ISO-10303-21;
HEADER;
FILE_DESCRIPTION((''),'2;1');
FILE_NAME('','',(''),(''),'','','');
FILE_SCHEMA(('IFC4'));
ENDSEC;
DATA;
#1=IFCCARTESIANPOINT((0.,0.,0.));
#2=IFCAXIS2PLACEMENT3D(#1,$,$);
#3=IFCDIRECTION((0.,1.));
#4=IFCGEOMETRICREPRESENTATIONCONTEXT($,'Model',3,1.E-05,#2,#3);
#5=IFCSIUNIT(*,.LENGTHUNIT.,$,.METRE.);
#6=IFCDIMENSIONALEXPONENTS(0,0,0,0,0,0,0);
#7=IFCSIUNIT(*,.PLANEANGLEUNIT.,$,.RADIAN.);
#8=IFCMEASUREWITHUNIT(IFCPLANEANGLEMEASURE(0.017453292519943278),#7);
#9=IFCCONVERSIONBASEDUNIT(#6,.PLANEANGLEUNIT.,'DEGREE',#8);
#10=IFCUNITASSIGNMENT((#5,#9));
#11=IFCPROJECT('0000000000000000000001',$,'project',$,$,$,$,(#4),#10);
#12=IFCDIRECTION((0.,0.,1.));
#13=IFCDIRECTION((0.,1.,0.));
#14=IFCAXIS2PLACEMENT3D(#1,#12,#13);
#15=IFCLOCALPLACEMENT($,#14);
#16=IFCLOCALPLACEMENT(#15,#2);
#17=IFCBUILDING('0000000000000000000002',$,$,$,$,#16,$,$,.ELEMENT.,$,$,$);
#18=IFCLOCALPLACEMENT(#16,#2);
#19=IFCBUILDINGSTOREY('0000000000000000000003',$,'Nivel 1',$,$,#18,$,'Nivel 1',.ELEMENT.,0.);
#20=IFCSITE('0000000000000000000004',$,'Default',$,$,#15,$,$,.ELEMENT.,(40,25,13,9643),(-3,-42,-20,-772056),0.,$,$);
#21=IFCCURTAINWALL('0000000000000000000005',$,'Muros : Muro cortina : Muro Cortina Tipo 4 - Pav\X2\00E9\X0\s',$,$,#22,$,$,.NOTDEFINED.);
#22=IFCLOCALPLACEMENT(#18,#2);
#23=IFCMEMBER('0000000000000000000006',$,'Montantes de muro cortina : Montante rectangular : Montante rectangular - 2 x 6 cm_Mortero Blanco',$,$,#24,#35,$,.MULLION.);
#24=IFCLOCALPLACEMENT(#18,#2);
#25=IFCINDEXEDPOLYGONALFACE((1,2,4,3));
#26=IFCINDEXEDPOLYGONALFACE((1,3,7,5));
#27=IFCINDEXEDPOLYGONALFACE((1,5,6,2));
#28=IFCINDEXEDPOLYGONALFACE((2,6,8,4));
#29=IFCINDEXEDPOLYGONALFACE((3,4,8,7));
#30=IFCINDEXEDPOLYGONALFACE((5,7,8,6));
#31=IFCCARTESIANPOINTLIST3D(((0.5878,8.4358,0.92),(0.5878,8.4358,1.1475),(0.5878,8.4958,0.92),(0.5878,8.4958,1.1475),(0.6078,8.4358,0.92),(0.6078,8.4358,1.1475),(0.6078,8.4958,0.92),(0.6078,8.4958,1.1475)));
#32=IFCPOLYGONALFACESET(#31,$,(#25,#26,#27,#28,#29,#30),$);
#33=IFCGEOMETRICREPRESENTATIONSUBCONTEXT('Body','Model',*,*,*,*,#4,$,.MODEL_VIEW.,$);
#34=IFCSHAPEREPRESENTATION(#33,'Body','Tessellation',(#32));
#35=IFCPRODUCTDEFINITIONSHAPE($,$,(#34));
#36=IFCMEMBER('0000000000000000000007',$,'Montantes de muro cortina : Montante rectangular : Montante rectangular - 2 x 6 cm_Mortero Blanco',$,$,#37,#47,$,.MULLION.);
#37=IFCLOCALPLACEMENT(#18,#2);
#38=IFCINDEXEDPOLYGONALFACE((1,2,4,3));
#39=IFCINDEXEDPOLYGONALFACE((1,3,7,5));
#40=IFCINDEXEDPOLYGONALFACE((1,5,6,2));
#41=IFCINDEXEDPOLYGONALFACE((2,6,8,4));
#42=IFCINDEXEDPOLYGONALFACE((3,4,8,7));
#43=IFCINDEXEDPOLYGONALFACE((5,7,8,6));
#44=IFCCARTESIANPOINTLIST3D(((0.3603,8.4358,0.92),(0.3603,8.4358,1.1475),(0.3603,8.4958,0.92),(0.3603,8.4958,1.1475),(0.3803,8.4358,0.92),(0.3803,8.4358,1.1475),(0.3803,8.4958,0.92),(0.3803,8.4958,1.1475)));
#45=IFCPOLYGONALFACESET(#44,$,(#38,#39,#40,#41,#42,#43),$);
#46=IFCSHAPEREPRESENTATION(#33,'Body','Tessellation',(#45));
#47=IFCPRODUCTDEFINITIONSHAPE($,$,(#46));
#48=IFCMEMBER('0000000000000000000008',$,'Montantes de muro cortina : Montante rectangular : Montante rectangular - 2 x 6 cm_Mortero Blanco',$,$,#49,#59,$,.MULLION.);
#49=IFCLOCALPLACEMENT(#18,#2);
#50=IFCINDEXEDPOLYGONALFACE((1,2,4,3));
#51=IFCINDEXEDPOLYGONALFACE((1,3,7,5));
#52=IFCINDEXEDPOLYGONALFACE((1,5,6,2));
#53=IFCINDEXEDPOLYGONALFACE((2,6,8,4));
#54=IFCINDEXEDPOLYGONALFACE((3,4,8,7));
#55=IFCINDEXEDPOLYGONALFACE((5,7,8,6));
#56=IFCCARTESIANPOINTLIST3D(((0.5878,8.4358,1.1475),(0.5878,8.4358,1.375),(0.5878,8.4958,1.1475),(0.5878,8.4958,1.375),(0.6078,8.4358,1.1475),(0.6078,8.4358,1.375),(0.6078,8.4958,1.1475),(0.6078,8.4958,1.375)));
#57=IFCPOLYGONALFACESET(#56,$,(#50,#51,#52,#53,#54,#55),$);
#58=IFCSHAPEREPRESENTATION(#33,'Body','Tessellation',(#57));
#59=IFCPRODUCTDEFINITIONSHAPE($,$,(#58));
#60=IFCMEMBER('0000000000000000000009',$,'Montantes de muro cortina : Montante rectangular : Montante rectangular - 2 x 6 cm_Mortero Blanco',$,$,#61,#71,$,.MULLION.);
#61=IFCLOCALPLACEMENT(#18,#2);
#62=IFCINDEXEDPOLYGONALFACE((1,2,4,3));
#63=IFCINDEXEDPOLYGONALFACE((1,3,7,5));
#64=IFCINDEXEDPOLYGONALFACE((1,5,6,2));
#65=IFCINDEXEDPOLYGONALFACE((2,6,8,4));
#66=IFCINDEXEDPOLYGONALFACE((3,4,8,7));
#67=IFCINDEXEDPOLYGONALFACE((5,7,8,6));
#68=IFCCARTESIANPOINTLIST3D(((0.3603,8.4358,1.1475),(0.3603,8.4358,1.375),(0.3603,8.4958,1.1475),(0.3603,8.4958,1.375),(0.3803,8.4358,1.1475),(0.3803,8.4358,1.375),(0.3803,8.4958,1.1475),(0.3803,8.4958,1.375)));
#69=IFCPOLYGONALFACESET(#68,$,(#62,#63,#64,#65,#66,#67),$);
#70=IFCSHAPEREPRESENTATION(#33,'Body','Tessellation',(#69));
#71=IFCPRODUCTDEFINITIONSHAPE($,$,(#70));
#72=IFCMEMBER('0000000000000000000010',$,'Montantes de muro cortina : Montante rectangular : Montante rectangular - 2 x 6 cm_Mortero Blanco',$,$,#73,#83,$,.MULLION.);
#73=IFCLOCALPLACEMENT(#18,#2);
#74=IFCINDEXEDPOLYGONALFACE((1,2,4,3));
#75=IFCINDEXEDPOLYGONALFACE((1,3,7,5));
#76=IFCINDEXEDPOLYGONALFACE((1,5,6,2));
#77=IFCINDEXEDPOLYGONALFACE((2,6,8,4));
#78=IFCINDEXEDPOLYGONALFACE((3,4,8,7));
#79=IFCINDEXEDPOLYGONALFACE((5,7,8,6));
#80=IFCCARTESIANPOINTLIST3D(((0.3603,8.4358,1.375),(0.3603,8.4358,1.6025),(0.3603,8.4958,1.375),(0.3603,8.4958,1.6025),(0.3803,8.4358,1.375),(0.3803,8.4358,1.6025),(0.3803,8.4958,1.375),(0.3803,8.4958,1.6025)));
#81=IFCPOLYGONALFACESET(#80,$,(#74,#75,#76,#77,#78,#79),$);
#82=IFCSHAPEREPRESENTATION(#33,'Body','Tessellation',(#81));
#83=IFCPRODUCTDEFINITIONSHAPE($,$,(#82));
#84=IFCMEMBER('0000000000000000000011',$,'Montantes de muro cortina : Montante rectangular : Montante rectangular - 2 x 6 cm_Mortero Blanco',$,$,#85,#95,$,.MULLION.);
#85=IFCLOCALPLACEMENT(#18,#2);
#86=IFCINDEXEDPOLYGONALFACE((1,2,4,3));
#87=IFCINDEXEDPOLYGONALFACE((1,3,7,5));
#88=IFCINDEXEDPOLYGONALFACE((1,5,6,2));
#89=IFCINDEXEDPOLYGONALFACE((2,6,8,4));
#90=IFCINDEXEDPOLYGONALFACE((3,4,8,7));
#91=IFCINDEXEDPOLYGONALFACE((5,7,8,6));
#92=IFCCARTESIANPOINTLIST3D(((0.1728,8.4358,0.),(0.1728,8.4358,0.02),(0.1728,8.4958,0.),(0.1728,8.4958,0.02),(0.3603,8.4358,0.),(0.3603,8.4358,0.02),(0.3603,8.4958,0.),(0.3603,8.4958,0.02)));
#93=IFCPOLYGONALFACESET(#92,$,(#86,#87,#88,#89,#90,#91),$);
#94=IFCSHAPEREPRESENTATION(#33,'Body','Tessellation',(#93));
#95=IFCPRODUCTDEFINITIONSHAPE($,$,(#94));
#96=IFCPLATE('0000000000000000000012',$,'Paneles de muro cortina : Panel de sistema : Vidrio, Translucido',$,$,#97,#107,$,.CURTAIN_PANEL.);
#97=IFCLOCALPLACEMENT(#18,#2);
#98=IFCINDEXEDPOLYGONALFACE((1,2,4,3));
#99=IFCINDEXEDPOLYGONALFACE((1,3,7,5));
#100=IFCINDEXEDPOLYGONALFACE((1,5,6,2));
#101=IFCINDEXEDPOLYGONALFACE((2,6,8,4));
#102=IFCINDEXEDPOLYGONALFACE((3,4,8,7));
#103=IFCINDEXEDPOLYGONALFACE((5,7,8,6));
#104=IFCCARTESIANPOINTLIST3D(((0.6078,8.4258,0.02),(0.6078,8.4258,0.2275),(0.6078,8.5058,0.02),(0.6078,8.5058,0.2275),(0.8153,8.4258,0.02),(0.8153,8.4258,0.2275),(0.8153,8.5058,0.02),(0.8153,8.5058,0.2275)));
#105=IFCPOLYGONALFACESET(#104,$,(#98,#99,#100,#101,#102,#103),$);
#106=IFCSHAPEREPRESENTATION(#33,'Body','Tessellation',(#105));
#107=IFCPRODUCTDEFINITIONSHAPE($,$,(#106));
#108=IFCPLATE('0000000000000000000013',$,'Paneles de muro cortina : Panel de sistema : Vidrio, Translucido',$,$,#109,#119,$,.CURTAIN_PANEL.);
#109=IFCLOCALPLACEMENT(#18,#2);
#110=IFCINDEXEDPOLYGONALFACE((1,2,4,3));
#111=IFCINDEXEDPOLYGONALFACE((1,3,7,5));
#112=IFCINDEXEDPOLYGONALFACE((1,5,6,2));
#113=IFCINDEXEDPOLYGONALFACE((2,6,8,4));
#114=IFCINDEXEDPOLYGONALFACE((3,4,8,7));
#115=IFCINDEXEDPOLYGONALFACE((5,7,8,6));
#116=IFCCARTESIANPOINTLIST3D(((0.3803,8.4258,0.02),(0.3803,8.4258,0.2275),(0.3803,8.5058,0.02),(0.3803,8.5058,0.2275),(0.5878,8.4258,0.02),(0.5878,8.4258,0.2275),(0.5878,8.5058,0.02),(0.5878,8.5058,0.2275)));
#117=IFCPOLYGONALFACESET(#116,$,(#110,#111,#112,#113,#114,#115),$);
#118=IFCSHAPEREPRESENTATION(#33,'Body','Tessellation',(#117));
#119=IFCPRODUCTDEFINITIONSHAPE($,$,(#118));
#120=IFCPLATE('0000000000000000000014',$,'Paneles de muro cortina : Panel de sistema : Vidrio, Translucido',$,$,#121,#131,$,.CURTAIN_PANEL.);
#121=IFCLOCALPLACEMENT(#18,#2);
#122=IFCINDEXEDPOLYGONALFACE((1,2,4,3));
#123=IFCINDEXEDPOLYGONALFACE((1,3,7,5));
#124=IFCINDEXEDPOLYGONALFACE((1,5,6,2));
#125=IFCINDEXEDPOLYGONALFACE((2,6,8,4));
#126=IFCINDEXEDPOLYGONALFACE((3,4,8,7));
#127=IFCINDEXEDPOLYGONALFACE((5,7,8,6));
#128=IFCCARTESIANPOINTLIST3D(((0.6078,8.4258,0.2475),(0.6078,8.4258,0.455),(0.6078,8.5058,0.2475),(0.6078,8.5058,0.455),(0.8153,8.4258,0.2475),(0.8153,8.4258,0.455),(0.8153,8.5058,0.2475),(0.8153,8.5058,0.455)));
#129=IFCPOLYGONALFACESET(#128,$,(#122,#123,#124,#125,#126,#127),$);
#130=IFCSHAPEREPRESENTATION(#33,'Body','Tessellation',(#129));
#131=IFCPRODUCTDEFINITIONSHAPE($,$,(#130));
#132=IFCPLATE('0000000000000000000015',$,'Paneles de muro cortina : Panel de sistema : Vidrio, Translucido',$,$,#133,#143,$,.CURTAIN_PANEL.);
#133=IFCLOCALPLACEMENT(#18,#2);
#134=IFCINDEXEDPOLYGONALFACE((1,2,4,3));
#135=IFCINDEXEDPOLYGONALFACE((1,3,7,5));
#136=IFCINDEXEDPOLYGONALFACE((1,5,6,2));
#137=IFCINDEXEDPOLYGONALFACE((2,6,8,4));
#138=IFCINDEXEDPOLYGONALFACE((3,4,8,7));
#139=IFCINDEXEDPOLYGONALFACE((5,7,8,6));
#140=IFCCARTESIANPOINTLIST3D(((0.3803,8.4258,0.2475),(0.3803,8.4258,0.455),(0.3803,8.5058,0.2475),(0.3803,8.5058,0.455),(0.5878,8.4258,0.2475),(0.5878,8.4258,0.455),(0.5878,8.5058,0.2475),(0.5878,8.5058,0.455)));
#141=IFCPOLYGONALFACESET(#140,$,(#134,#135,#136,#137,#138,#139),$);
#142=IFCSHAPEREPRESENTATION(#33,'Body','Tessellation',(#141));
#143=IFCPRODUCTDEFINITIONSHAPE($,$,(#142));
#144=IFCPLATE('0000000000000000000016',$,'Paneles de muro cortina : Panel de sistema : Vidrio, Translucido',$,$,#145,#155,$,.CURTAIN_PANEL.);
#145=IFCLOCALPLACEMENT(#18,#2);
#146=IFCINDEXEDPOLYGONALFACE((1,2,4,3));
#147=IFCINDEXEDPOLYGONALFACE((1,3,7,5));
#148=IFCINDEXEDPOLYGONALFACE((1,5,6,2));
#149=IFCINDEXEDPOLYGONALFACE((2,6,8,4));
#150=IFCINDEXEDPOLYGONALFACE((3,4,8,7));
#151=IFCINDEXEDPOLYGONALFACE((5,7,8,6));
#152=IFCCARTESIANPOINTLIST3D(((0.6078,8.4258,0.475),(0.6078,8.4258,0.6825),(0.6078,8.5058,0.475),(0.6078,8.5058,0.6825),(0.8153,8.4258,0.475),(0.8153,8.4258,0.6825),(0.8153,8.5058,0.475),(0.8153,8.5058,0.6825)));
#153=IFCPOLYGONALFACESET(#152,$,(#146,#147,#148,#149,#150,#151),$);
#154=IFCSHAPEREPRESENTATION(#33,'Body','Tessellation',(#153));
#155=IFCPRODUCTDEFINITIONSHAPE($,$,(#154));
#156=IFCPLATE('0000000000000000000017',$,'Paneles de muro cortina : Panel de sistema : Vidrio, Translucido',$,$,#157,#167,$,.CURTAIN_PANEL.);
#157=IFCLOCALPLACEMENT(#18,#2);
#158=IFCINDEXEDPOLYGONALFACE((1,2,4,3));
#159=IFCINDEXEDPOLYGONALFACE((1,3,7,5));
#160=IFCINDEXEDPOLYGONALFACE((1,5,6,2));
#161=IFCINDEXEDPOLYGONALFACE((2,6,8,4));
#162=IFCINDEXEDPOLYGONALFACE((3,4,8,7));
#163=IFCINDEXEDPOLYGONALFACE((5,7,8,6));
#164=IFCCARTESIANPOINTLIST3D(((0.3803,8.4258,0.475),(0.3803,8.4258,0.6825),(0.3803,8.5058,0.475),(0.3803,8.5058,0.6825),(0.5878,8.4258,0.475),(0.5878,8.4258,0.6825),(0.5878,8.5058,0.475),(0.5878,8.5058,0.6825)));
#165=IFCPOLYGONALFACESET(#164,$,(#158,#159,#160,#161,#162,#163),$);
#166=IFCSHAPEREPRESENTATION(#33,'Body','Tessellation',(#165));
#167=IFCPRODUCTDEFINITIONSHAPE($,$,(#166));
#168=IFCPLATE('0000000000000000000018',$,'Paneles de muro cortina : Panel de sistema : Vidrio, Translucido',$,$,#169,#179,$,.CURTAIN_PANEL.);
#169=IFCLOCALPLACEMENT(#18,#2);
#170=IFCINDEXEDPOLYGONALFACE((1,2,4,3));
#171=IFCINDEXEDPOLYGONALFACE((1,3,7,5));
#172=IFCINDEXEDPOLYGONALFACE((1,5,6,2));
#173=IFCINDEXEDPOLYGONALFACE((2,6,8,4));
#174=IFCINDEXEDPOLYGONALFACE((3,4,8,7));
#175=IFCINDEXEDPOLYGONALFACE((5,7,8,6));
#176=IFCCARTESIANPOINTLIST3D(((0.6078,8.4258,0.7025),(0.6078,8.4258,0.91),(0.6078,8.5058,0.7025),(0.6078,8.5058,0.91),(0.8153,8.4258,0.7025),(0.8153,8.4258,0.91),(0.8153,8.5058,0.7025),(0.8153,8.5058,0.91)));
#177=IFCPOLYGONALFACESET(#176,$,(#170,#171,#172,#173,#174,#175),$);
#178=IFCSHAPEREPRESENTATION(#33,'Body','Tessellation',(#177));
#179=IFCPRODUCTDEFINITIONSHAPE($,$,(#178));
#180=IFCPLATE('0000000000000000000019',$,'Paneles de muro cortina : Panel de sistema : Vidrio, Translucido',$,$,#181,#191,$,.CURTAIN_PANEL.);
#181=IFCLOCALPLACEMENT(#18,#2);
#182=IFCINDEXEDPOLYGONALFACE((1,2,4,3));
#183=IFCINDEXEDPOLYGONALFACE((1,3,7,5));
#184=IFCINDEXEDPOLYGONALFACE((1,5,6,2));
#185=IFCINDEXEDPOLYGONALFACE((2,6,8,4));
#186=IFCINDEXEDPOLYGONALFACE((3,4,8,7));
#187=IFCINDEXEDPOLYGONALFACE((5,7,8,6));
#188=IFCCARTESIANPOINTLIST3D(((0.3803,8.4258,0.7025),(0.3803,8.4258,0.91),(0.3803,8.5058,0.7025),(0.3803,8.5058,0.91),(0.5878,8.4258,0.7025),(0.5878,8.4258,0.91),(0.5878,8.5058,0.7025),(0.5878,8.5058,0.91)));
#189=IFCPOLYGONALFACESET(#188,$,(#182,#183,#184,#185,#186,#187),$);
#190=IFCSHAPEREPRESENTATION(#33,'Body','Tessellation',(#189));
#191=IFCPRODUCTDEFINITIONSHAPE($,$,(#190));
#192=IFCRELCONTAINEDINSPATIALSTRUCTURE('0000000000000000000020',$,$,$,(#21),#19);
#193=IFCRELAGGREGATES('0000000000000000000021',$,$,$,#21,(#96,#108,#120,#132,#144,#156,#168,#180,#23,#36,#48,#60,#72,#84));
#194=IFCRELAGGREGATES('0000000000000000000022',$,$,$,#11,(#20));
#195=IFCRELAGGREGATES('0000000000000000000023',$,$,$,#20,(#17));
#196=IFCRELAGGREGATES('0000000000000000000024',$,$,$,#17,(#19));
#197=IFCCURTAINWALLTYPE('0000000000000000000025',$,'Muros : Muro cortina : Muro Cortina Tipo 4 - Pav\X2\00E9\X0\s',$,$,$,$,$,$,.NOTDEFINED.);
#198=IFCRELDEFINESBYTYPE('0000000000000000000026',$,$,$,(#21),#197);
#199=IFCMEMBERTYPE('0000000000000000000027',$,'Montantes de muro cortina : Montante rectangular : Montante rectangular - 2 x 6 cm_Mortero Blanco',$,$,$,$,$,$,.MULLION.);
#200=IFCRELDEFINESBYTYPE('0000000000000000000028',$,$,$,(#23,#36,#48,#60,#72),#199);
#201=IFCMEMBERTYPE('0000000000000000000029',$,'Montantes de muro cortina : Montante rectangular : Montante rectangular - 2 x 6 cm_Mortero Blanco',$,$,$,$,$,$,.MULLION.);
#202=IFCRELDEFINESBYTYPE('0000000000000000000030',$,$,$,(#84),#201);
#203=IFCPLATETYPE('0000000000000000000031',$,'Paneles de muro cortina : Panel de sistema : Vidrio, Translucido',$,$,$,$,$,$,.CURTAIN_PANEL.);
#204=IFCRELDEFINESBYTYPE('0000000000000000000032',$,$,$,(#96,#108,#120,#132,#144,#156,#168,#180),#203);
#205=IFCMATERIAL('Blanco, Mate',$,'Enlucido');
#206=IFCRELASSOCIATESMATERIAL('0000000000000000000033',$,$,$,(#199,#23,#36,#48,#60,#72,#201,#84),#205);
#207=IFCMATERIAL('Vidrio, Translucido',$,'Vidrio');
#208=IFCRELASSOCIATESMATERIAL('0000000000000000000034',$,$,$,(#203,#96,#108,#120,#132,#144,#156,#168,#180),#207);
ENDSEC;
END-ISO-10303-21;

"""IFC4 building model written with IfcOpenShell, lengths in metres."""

from ifc_helpers import new_model, entity, si_unit, converted_unit, direction, frame, origin, place, context, subcontext, project, spatial, indexed_curve, outline, extrude, source, transform, mapped, material, type_object, type_shapes, element, aggregate, save


model = new_model("IFC4")

# Units and contexts
model_context = context("Model", 3, precision=1e-05, world=origin(), true_north=direction((0.0, 1.0)))
body_context = subcontext(model_context, "Body", "Model", "MODEL_VIEW")
ifc_project = project(units=[si_unit("LENGTHUNIT", "METRE"), converted_unit("PLANEANGLEUNIT", "DEGREE", entity("IfcPlaneAngleMeasure", 0.017453292519943278), si_unit("PLANEANGLEUNIT", "RADIAN"), dimensions=[0, 0, 0, 0, 0, 0, 0])], contexts=[model_context])

# Site, building, storey
site_placement = place(None, frame((0.0, 0.0, 0.0), z_axis=(0.0, 0.0, 1.0), x_axis=(0.0, 1.0, 0.0)))
site = spatial("IfcSite", under=ifc_project, at=site_placement, Name="Default", CompositionType="ELEMENT", RefLatitude=(40, 25, 13, 9643), RefLongitude=(-3, -42, -20, -772056), RefElevation=0.0)
building_placement = place(site_placement, origin())
building = spatial("IfcBuilding", under=site, at=building_placement, CompositionType="ELEMENT")
storey_placement = place(building_placement, origin())
storey = spatial("IfcBuildingStorey", under=building, at=storey_placement, Name="Nivel 1", LongName="Nivel 1", CompositionType="ELEMENT", Elevation=0.0)

# Curtain wall, members, plates
curtain_wall_type = type_object("IfcCurtainWallType", Name="Muros : Muro cortina : Muro Cortina Tipo 4 - Pavés", PredefinedType="NOTDEFINED")
curtain_wall_placement = place(storey_placement, origin())
curtain_wall = element("IfcCurtainWall", 1, at=curtain_wall_placement, inside=storey, type_object=curtain_wall_type, Name="Muros : Muro cortina : Muro Cortina Tipo 4 - Pavés", PredefinedType="NOTDEFINED")
ifc_material_1 = material(Name="Blanco, Mate", Category="Enlucido")
member_type_1 = type_object("IfcMemberType", Name="Montantes de muro cortina : Montante rectangular : Montante rectangular - 2 x 6 cm_Mortero Blanco", PredefinedType="MULLION", material=ifc_material_1)
shared_shape_1 = source(origin(), body_context, "Body", "SweptSolid", [
    extrude(outline(indexed_curve([(-0.01, -0.03), (0.01, -0.03), (0.01, 0.03), (-0.01, 0.03), (-0.01, -0.03)], self_intersect=False)), frame((0.0, 0.0, -0.2275), z_axis=(0.0, 0.0, 1.0), x_axis=(-1.0, 0.0, 0.0)), (0.0, 0.0, 1.0), 0.2275),
])
type_shapes(member_type_1, [shared_shape_1])
member_1_placement = place(curtain_wall_placement, frame((0.5978, 8.4658, 0.92), z_axis=(0.0, 0.0, -1.0), x_axis=(-1.0, 0.0, 0.0)))
member_1 = element("IfcMember", 2, at=member_1_placement, type_object=member_type_1, material=ifc_material_1, Name="Montantes de muro cortina : Montante rectangular : Montante rectangular - 2 x 6 cm_Mortero Blanco", PredefinedType="MULLION", context=body_context, shape_type="MappedRepresentation", body=[
    mapped(shared_shape_1, transform((0.0, 0.0, 0.0), scale=1.0)),
])
member_2_placement = place(curtain_wall_placement, frame((0.3703, 8.4658, 0.92), z_axis=(0.0, 0.0, -1.0), x_axis=(-1.0, 0.0, 0.0)))
member_2 = element("IfcMember", 3, at=member_2_placement, type_object=member_type_1, material=ifc_material_1, Name="Montantes de muro cortina : Montante rectangular : Montante rectangular - 2 x 6 cm_Mortero Blanco", PredefinedType="MULLION", context=body_context, shape_type="MappedRepresentation", body=[
    mapped(shared_shape_1, transform((0.0, 0.0, 0.0), scale=1.0)),
])
member_3_placement = place(curtain_wall_placement, frame((0.5978, 8.4658, 1.1475), z_axis=(0.0, 0.0, -1.0), x_axis=(-1.0, 0.0, 0.0)))
member_3 = element("IfcMember", 4, at=member_3_placement, type_object=member_type_1, material=ifc_material_1, Name="Montantes de muro cortina : Montante rectangular : Montante rectangular - 2 x 6 cm_Mortero Blanco", PredefinedType="MULLION", context=body_context, shape_type="MappedRepresentation", body=[
    mapped(shared_shape_1, transform((0.0, 0.0, 0.0), scale=1.0)),
])
member_4_placement = place(curtain_wall_placement, frame((0.3703, 8.4658, 1.1475), z_axis=(0.0, 0.0, -1.0), x_axis=(-1.0, 0.0, 0.0)))
member_4 = element("IfcMember", 5, at=member_4_placement, type_object=member_type_1, material=ifc_material_1, Name="Montantes de muro cortina : Montante rectangular : Montante rectangular - 2 x 6 cm_Mortero Blanco", PredefinedType="MULLION", context=body_context, shape_type="MappedRepresentation", body=[
    mapped(shared_shape_1, transform((0.0, 0.0, 0.0), scale=1.0)),
])
member_5_placement = place(curtain_wall_placement, frame((0.3703, 8.4658, 1.375), z_axis=(0.0, 0.0, -1.0), x_axis=(-1.0, 0.0, 0.0)))
member_5 = element("IfcMember", 6, at=member_5_placement, type_object=member_type_1, material=ifc_material_1, Name="Montantes de muro cortina : Montante rectangular : Montante rectangular - 2 x 6 cm_Mortero Blanco", PredefinedType="MULLION", context=body_context, shape_type="MappedRepresentation", body=[
    mapped(shared_shape_1, transform((0.0, 0.0, 0.0), scale=1.0)),
])
member_type_2 = type_object("IfcMemberType", Name="Montantes de muro cortina : Montante rectangular : Montante rectangular - 2 x 6 cm_Mortero Blanco", PredefinedType="MULLION", material=ifc_material_1)
shared_shape_2 = source(origin(), body_context, "Body", "SweptSolid", [
    extrude(outline(indexed_curve([(-0.01, -0.03), (0.01, -0.03), (0.01, 0.03), (-0.01, 0.03), (-0.01, -0.03)], self_intersect=False)), frame((-0.01, 0.0, -0.1875), z_axis=(0.0, 0.0, 1.0), x_axis=(-1.0, 0.0, 0.0)), (0.0, 0.0, 1.0), 0.1875),
])
type_shapes(member_type_2, [shared_shape_2])
member_6_placement = place(curtain_wall_placement, frame((0.3603, 8.4658, 0.0), z_axis=(1.0, 0.0, 0.0), x_axis=(0.0, 0.0, -1.0)))
member_6 = element("IfcMember", 7, at=member_6_placement, type_object=member_type_2, material=ifc_material_1, Name="Montantes de muro cortina : Montante rectangular : Montante rectangular - 2 x 6 cm_Mortero Blanco", PredefinedType="MULLION", context=body_context, shape_type="MappedRepresentation", body=[
    mapped(shared_shape_2, transform((0.0, 0.0, 0.0), scale=1.0)),
])
ifc_material_2 = material(Name="Vidrio, Translucido", Category="Vidrio")
plate_type = type_object("IfcPlateType", Name="Paneles de muro cortina : Panel de sistema : Vidrio, Translucido", PredefinedType="CURTAIN_PANEL", material=ifc_material_2)
shared_shape_3 = source(origin(), body_context, "Body", "SweptSolid", [
    extrude(outline(indexed_curve([(-0.04, -0.1038), (0.04, -0.1038), (0.04, 0.1038), (-0.04, 0.1038), (-0.04, -0.1038)], self_intersect=False)), frame((0.0, 0.0, 0.0), z_axis=(0.0, 0.0, 1.0), x_axis=(0.0, 1.0, 0.0)), (0.0, 0.0, 1.0), 0.2075),
])
type_shapes(plate_type, [shared_shape_3])
plate_1_placement = place(curtain_wall_placement, frame((0.7115, 8.4658, 0.02), z_axis=(0.0, 0.0, 1.0), x_axis=(-1.0, 0.0, 0.0)))
plate_1 = element("IfcPlate", 8, at=plate_1_placement, type_object=plate_type, material=ifc_material_2, Name="Paneles de muro cortina : Panel de sistema : Vidrio, Translucido", PredefinedType="CURTAIN_PANEL", context=body_context, shape_type="MappedRepresentation", body=[
    mapped(shared_shape_3, transform((0.0, 0.0, 0.0), scale=1.0)),
])
plate_2_placement = place(curtain_wall_placement, frame((0.484, 8.4658, 0.02), z_axis=(0.0, 0.0, 1.0), x_axis=(-1.0, 0.0, 0.0)))
plate_2 = element("IfcPlate", 9, at=plate_2_placement, type_object=plate_type, material=ifc_material_2, Name="Paneles de muro cortina : Panel de sistema : Vidrio, Translucido", PredefinedType="CURTAIN_PANEL", context=body_context, shape_type="MappedRepresentation", body=[
    mapped(shared_shape_3, transform((0.0, 0.0, 0.0), scale=1.0)),
])
plate_3_placement = place(curtain_wall_placement, frame((0.7115, 8.4658, 0.2475), z_axis=(0.0, 0.0, 1.0), x_axis=(-1.0, 0.0, 0.0)))
plate_3 = element("IfcPlate", 10, at=plate_3_placement, type_object=plate_type, material=ifc_material_2, Name="Paneles de muro cortina : Panel de sistema : Vidrio, Translucido", PredefinedType="CURTAIN_PANEL", context=body_context, shape_type="MappedRepresentation", body=[
    mapped(shared_shape_3, transform((0.0, 0.0, 0.0), scale=1.0)),
])
plate_4_placement = place(curtain_wall_placement, frame((0.484, 8.4658, 0.2475), z_axis=(0.0, 0.0, 1.0), x_axis=(-1.0, 0.0, 0.0)))
plate_4 = element("IfcPlate", 11, at=plate_4_placement, type_object=plate_type, material=ifc_material_2, Name="Paneles de muro cortina : Panel de sistema : Vidrio, Translucido", PredefinedType="CURTAIN_PANEL", context=body_context, shape_type="MappedRepresentation", body=[
    mapped(shared_shape_3, transform((0.0, 0.0, 0.0), scale=1.0)),
])
plate_5_placement = place(curtain_wall_placement, frame((0.7115, 8.4658, 0.475), z_axis=(0.0, 0.0, 1.0), x_axis=(-1.0, 0.0, 0.0)))
plate_5 = element("IfcPlate", 12, at=plate_5_placement, type_object=plate_type, material=ifc_material_2, Name="Paneles de muro cortina : Panel de sistema : Vidrio, Translucido", PredefinedType="CURTAIN_PANEL", context=body_context, shape_type="MappedRepresentation", body=[
    mapped(shared_shape_3, transform((0.0, 0.0, 0.0), scale=1.0)),
])
plate_6_placement = place(curtain_wall_placement, frame((0.484, 8.4658, 0.475), z_axis=(0.0, 0.0, 1.0), x_axis=(-1.0, 0.0, 0.0)))
plate_6 = element("IfcPlate", 13, at=plate_6_placement, type_object=plate_type, material=ifc_material_2, Name="Paneles de muro cortina : Panel de sistema : Vidrio, Translucido", PredefinedType="CURTAIN_PANEL", context=body_context, shape_type="MappedRepresentation", body=[
    mapped(shared_shape_3, transform((0.0, 0.0, 0.0), scale=1.0)),
])
plate_7_placement = place(curtain_wall_placement, frame((0.7115, 8.4658, 0.7025), z_axis=(0.0, 0.0, 1.0), x_axis=(-1.0, 0.0, 0.0)))
plate_7 = element("IfcPlate", 14, at=plate_7_placement, type_object=plate_type, material=ifc_material_2, Name="Paneles de muro cortina : Panel de sistema : Vidrio, Translucido", PredefinedType="CURTAIN_PANEL", context=body_context, shape_type="MappedRepresentation", body=[
    mapped(shared_shape_3, transform((0.0, 0.0, 0.0), scale=1.0)),
])
plate_8_placement = place(curtain_wall_placement, frame((0.484, 8.4658, 0.7025), z_axis=(0.0, 0.0, 1.0), x_axis=(-1.0, 0.0, 0.0)))
plate_8 = element("IfcPlate", 15, at=plate_8_placement, type_object=plate_type, material=ifc_material_2, Name="Paneles de muro cortina : Panel de sistema : Vidrio, Translucido", PredefinedType="CURTAIN_PANEL", context=body_context, shape_type="MappedRepresentation", body=[
    mapped(shared_shape_3, transform((0.0, 0.0, 0.0), scale=1.0)),
])
aggregate(curtain_wall, [plate_1, plate_2, plate_3, plate_4, plate_5, plate_6, plate_7, plate_8, member_1, member_2, member_3, member_4, member_5, member_6])

save(model, "model.ifc")
